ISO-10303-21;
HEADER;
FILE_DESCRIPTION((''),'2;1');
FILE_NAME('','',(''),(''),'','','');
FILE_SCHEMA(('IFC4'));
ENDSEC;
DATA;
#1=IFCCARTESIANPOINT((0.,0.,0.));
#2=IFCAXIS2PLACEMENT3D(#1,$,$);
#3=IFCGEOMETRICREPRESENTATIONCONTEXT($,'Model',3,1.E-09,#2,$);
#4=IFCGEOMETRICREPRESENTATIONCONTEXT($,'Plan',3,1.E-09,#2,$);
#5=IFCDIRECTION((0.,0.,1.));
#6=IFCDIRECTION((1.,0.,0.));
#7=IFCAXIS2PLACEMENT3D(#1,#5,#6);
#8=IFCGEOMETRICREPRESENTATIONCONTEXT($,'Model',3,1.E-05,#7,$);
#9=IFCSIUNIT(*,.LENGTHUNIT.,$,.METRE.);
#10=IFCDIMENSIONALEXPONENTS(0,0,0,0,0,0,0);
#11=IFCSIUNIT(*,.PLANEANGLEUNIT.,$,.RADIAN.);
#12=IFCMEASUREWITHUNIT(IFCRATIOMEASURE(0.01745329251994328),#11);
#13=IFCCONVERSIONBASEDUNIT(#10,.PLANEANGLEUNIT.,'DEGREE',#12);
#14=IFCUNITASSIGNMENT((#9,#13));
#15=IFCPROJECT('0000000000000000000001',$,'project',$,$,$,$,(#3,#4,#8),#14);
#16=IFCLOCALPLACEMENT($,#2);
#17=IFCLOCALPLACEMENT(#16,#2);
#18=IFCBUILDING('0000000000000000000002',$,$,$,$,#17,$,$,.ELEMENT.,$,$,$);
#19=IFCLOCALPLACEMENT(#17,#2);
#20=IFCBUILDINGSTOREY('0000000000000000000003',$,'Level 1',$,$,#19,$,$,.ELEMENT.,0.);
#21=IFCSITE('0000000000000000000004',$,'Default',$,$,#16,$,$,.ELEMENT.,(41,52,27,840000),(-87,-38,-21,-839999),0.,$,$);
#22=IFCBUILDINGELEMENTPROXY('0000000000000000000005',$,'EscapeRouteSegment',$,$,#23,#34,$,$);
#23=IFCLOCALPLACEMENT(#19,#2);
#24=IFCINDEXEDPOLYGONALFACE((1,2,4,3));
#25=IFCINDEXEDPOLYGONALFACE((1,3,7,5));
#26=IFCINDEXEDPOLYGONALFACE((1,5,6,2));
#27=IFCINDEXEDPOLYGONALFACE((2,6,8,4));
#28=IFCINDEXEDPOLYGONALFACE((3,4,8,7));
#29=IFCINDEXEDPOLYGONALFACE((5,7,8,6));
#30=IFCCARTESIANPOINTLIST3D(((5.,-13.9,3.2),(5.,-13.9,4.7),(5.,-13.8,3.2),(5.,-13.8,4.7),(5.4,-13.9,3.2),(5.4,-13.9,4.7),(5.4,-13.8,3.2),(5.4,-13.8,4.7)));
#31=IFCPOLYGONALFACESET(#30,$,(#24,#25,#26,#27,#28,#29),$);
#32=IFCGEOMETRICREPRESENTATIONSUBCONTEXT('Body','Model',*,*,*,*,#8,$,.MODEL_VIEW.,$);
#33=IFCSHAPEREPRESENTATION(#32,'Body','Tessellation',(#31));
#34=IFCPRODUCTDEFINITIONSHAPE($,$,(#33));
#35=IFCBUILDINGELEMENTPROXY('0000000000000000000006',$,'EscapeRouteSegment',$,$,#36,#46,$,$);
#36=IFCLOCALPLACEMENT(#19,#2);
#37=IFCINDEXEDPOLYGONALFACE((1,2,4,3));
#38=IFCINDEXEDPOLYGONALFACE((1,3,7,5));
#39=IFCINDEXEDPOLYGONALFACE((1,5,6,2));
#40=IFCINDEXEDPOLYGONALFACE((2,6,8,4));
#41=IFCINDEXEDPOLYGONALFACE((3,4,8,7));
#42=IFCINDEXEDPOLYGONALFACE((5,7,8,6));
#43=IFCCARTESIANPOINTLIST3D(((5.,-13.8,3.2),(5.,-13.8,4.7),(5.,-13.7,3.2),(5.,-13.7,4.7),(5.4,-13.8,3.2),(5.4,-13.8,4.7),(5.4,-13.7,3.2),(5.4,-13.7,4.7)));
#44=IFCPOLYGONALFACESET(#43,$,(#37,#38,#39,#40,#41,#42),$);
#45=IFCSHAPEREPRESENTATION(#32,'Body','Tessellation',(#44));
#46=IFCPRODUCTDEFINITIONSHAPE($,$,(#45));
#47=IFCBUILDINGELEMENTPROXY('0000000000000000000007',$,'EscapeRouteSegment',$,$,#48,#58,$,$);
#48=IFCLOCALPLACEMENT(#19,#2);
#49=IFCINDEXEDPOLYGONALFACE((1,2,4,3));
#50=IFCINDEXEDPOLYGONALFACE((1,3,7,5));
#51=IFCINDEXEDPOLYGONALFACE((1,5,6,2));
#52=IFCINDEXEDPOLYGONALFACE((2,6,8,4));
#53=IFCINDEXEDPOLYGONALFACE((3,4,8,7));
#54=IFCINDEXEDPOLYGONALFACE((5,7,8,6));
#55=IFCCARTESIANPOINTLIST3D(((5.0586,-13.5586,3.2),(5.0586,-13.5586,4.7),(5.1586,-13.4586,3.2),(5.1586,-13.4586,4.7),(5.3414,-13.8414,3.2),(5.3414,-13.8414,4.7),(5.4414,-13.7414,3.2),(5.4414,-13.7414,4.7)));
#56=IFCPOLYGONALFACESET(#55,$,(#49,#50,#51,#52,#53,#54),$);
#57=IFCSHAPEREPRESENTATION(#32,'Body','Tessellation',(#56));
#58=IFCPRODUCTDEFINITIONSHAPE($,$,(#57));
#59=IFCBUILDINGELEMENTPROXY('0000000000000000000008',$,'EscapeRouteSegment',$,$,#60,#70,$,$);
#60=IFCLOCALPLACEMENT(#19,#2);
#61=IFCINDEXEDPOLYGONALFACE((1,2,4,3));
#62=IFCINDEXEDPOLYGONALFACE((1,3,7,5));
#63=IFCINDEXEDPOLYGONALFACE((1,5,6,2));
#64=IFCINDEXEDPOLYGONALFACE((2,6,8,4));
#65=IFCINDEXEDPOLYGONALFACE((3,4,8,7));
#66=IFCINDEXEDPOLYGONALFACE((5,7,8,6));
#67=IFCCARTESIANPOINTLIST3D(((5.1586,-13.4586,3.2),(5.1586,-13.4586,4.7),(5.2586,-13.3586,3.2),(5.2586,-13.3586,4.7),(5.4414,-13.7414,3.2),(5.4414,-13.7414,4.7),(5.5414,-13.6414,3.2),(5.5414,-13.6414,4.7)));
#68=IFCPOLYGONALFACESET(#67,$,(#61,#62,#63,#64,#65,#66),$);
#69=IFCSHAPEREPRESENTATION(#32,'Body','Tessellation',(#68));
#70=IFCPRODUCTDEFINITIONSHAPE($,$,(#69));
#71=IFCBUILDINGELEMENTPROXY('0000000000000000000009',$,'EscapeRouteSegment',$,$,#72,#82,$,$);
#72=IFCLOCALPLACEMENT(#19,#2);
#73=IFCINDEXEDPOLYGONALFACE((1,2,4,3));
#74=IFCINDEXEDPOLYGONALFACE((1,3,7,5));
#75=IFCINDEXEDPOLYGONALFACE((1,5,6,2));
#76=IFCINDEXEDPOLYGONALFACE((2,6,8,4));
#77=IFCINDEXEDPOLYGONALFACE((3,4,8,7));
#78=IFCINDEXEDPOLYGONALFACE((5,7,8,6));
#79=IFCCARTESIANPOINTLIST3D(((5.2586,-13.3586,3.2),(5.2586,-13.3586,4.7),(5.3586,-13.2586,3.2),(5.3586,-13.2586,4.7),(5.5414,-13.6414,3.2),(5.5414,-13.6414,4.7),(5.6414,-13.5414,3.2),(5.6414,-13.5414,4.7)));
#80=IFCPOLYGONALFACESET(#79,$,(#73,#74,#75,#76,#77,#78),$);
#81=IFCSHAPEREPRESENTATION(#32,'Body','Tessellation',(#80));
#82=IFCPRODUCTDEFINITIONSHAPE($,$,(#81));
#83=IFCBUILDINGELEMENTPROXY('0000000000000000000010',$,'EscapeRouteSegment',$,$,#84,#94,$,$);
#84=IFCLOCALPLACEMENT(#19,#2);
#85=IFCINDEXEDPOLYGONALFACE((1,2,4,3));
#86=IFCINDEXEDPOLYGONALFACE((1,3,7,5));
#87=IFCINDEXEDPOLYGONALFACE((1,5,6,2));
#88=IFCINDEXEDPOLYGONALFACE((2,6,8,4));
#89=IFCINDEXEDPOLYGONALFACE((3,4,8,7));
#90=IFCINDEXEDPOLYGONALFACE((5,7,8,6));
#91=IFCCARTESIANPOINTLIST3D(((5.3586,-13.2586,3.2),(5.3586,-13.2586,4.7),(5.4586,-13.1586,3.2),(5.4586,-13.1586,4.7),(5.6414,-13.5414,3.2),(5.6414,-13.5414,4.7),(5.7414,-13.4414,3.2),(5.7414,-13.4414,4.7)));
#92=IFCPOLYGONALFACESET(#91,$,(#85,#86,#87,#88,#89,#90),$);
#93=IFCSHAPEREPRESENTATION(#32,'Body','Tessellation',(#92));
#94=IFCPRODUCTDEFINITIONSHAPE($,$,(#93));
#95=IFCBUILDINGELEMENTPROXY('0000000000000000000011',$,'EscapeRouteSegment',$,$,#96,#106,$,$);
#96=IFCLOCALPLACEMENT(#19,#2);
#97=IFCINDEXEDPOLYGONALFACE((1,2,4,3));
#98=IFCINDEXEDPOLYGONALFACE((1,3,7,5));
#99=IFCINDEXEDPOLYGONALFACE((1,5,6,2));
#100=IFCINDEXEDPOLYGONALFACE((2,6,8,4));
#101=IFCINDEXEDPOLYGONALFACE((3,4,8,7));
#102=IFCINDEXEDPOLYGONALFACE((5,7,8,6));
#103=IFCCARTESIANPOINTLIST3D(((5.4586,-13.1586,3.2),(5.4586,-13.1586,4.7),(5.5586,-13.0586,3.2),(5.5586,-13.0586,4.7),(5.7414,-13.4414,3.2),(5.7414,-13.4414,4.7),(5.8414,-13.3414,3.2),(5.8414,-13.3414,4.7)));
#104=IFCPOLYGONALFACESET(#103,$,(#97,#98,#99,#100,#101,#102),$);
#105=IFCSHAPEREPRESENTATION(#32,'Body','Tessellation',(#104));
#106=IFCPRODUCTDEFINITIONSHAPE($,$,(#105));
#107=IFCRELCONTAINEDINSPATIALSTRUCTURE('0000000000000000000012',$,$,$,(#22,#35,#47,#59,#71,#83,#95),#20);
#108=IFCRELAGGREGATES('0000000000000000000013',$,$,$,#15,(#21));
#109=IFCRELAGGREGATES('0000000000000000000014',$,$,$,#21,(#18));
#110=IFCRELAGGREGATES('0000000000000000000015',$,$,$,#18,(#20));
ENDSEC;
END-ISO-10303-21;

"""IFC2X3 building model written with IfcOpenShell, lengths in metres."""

from ifc_helpers import new_model, entity, si_unit, converted_unit, frame, origin, origin_with_axes, place, context, subcontext, project, spatial, polyline, outline, extrude, element, save


model = new_model("IFC2X3")

# Units and contexts
model_context_1 = context("Model", 3, precision=1e-09, world=origin())
plan_context = context("Plan", 3, precision=1e-09, world=origin())
model_context_2 = context("Model", 3, precision=1e-05, world=origin_with_axes())
body_context = subcontext(model_context_2, "Body", "Model", "MODEL_VIEW")
ifc_project = project(units=[si_unit("LENGTHUNIT", "METRE"), converted_unit("PLANEANGLEUNIT", "DEGREE", entity("IfcRatioMeasure", 0.01745329251994328), si_unit("PLANEANGLEUNIT", "RADIAN"), dimensions=[0, 0, 0, 0, 0, 0, 0])], contexts=[model_context_1, plan_context, model_context_2])

# Site, building, storey
site_placement = place(None, origin())
site = spatial("IfcSite", under=ifc_project, at=site_placement, Name="Default", CompositionType="ELEMENT", RefLatitude=(41, 52, 27, 840000), RefLongitude=(-87, -38, -21, -839999), RefElevation=0.0)
building_placement = place(site_placement, origin())
building = spatial("IfcBuilding", under=site, at=building_placement, CompositionType="ELEMENT")
storey_placement = place(building_placement, origin())
storey = spatial("IfcBuildingStorey", under=building, at=storey_placement, Name="Level 1", CompositionType="ELEMENT", Elevation=0.0)

# Building element proxies
proxy_1_placement = place(storey_placement, frame((5.2, -13.9, 3.2), z_axis=(0.0, 0.0, 1.0), x_axis=(0.0, 1.0, 0.0)))
element("IfcBuildingElementProxy", 1, at=proxy_1_placement, inside=storey, Name="EscapeRouteSegment", context=body_context, shape_type="SweptSolid", body=[
    extrude(outline(polyline([(0.0, -0.2), (0.0, 0.2), (0.1, 0.2), (0.1, -0.2), (0.0, -0.2)])), origin_with_axes(), (0.0, 0.0, 1.0), 1.5),
])
proxy_2_placement = place(storey_placement, frame((5.2, -13.8, 3.2), z_axis=(0.0, 0.0, 1.0), x_axis=(0.0, 1.0, 0.0)))
element("IfcBuildingElementProxy", 2, at=proxy_2_placement, inside=storey, Name="EscapeRouteSegment", context=body_context, shape_type="SweptSolid", body=[
    extrude(outline(polyline([(0.0, -0.2), (0.0, 0.2), (0.1, 0.2), (0.1, -0.2), (0.0, -0.2)])), origin_with_axes(), (0.0, 0.0, 1.0), 1.5),
])
proxy_3_placement = place(storey_placement, frame((5.2, -13.7, 3.2), z_axis=(0.0, 0.0, 1.0), x_axis=(0.70711, 0.707104, 0.0)))
element("IfcBuildingElementProxy", 3, at=proxy_3_placement, inside=storey, Name="EscapeRouteSegment", context=body_context, shape_type="SweptSolid", body=[
    extrude(outline(polyline([(0.0, -0.2), (0.0, 0.2), (0.1414, 0.2), (0.1414, -0.2), (0.0, -0.2)])), origin_with_axes(), (0.0, 0.0, 1.0), 1.5),
])
for number, where, z_axis, x_axis, name in (
    (4, (5.3, -13.6, 3.2), (0.0, 0.0, 1.0), (0.707105, 0.707108, 0.0), "EscapeRouteSegment"),
    (5, (5.4, -13.5, 3.2), (0.0, 0.0, 1.0), (0.707105, 0.707108, 0.0), "EscapeRouteSegment"),
):
    element("IfcBuildingElementProxy", number, at=place(storey_placement, frame(where, z_axis=z_axis, x_axis=x_axis)), inside=storey, Name=name, context=body_context, shape_type="SweptSolid", body=[
        extrude(outline(polyline([(0.0, -0.2), (0.0, 0.2), (0.1414, 0.2), (0.1414, -0.2), (0.0, -0.2)])), origin_with_axes(), (0.0, 0.0, 1.0), 1.5),
    ])
proxy_4_placement = place(storey_placement, frame((5.5, -13.4, 3.2), z_axis=(0.0, 0.0, 1.0), x_axis=(0.707108, 0.707105, 0.0)))
element("IfcBuildingElementProxy", 6, at=proxy_4_placement, inside=storey, Name="EscapeRouteSegment", context=body_context, shape_type="SweptSolid", body=[
    extrude(outline(polyline([(0.0, -0.2), (0.0, 0.2), (0.1414, 0.2), (0.1414, -0.2), (0.0, -0.2)])), origin_with_axes(), (0.0, 0.0, 1.0), 1.5),
])
proxy_5_placement = place(storey_placement, frame((5.6, -13.3, 3.2), z_axis=(0.0, 0.0, 1.0), x_axis=(0.707105, 0.707108, 0.0)))
element("IfcBuildingElementProxy", 7, at=proxy_5_placement, inside=storey, Name="EscapeRouteSegment", context=body_context, shape_type="SweptSolid", body=[
    extrude(outline(polyline([(0.0, -0.2), (0.0, 0.2), (0.1414, 0.2), (0.1414, -0.2), (0.0, -0.2)])), origin_with_axes(), (0.0, 0.0, 1.0), 1.5),
])

save(model, "model.ifc")
